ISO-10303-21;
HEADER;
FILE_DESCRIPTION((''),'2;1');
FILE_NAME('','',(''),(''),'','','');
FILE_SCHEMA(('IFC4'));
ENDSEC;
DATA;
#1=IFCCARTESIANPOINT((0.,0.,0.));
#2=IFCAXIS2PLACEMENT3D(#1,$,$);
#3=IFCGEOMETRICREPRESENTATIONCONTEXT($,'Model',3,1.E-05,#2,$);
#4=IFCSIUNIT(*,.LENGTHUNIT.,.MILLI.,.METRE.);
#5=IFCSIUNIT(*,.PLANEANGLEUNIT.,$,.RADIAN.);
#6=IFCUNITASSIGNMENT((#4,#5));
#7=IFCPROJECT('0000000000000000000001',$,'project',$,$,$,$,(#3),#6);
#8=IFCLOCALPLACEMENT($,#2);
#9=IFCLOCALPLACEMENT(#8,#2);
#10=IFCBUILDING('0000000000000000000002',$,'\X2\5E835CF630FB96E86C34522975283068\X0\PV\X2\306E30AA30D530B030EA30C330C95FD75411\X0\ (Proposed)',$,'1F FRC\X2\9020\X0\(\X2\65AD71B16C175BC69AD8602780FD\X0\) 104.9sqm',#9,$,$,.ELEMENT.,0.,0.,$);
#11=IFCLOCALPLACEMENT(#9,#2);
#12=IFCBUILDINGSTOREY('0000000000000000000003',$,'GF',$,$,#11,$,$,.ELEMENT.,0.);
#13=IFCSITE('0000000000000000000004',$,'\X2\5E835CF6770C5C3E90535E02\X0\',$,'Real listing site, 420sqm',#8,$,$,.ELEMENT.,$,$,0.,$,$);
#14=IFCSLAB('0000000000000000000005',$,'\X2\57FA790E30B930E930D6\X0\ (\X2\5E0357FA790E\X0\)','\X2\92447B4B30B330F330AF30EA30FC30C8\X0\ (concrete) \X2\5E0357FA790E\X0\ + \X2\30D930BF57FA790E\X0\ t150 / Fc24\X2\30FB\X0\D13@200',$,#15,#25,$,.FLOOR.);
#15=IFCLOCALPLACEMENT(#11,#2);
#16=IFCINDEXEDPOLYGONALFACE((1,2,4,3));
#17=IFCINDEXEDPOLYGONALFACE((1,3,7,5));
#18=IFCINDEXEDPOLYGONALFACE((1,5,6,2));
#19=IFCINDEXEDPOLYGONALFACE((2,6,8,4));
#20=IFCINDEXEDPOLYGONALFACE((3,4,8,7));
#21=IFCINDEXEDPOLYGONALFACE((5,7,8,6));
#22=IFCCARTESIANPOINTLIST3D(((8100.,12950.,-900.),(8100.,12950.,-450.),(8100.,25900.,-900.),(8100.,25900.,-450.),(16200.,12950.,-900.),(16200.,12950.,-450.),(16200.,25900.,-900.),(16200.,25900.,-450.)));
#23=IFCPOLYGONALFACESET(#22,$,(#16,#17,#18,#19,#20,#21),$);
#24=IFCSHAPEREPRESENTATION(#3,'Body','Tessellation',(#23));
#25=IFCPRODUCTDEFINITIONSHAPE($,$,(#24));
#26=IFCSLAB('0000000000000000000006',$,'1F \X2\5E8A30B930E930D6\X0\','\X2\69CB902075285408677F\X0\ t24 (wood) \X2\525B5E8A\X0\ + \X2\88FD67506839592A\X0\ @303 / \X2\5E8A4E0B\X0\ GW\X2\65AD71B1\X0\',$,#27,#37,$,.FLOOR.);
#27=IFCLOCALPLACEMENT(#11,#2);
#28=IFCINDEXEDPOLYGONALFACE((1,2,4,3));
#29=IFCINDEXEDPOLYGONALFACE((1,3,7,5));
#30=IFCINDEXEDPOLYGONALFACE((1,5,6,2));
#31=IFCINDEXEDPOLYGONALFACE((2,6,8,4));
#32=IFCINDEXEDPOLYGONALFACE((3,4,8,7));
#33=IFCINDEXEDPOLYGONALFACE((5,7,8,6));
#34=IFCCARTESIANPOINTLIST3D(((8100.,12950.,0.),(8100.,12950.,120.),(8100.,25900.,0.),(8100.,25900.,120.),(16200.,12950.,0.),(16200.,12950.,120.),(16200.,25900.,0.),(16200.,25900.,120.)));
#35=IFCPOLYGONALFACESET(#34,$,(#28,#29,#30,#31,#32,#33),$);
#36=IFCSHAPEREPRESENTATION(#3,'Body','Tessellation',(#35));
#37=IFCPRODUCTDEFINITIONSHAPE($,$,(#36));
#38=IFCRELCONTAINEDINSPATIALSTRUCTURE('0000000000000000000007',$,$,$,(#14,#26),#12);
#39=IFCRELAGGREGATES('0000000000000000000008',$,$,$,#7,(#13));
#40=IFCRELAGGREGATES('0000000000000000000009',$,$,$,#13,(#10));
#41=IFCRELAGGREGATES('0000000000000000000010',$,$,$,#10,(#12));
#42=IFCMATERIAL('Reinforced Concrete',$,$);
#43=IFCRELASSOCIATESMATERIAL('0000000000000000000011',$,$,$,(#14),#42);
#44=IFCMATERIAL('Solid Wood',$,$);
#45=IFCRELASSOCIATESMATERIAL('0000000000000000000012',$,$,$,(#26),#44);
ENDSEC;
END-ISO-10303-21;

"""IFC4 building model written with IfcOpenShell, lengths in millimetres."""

from ifc_helpers import new_model, si_unit, frame, frame_2d, origin, place, context, project, spatial, rectangle, extrude, material, element, save


model = new_model("IFC4")

# Units and contexts
model_context = context("Model", 3, precision=1e-05, world=origin())
ifc_project = project(units=[si_unit("LENGTHUNIT", "METRE", prefix="MILLI"), si_unit("PLANEANGLEUNIT", "RADIAN")], contexts=[model_context])

# Site, building, storey
site_placement = place(None, origin())
site = spatial("IfcSite", under=ifc_project, at=site_placement, Name="広島県尾道市", ObjectType="Real listing site, 420sqm", CompositionType="ELEMENT", RefElevation=0.0)
building_placement = place(site_placement, origin())
building = spatial("IfcBuilding", under=site, at=building_placement, Name="広島・雨水利用とPVのオフグリッド志向 (Proposed)", ObjectType="1F FRC造(断熱気密高性能) 104.9sqm", CompositionType="ELEMENT", ElevationOfRefHeight=0.0, ElevationOfTerrain=0.0)
storey_placement = place(building_placement, origin())
storey = spatial("IfcBuildingStorey", under=building, at=storey_placement, Name="GF", CompositionType="ELEMENT", Elevation=0.0)

# Shared definitions
ifc_material_1 = material(Name="Solid Wood")

# Slabs
ifc_material_2 = material(Name="Reinforced Concrete")
slab_1_placement = place(storey_placement, frame((4050.0, 6475.0, -450.0)))
element("IfcSlab", 1, at=slab_1_placement, inside=storey, material=ifc_material_2, Name="基礎スラブ (布基礎)", Description="鉄筋コンクリート (concrete) 布基礎 + ベタ基礎 t150 / Fc24・D13@200", PredefinedType="FLOOR", context=model_context, shape_type="SweptSolid", body=[
    extrude(rectangle(XDim=8100.0, YDim=12950.0, at=frame_2d((4050.0, 6475.0))), frame((4050.0, 6475.0, -450.0)), (0.0, 0.0, 1.0), 450.0),
])
slab_2_placement = place(storey_placement, frame((4050.0, 6475.0, 0.0)))
element("IfcSlab", 2, at=slab_2_placement, inside=storey, material=ifc_material_1, Name="1F 床スラブ", Description="構造用合板 t24 (wood) 剛床 + 製材根太 @303 / 床下 GW断熱", PredefinedType="FLOOR", context=model_context, shape_type="SweptSolid", body=[
    extrude(rectangle(XDim=8100.0, YDim=12950.0, at=frame_2d((4050.0, 6475.0))), frame((4050.0, 6475.0, 0.0)), (0.0, 0.0, 1.0), 120.0),
])

save(model, "model.ifc")
